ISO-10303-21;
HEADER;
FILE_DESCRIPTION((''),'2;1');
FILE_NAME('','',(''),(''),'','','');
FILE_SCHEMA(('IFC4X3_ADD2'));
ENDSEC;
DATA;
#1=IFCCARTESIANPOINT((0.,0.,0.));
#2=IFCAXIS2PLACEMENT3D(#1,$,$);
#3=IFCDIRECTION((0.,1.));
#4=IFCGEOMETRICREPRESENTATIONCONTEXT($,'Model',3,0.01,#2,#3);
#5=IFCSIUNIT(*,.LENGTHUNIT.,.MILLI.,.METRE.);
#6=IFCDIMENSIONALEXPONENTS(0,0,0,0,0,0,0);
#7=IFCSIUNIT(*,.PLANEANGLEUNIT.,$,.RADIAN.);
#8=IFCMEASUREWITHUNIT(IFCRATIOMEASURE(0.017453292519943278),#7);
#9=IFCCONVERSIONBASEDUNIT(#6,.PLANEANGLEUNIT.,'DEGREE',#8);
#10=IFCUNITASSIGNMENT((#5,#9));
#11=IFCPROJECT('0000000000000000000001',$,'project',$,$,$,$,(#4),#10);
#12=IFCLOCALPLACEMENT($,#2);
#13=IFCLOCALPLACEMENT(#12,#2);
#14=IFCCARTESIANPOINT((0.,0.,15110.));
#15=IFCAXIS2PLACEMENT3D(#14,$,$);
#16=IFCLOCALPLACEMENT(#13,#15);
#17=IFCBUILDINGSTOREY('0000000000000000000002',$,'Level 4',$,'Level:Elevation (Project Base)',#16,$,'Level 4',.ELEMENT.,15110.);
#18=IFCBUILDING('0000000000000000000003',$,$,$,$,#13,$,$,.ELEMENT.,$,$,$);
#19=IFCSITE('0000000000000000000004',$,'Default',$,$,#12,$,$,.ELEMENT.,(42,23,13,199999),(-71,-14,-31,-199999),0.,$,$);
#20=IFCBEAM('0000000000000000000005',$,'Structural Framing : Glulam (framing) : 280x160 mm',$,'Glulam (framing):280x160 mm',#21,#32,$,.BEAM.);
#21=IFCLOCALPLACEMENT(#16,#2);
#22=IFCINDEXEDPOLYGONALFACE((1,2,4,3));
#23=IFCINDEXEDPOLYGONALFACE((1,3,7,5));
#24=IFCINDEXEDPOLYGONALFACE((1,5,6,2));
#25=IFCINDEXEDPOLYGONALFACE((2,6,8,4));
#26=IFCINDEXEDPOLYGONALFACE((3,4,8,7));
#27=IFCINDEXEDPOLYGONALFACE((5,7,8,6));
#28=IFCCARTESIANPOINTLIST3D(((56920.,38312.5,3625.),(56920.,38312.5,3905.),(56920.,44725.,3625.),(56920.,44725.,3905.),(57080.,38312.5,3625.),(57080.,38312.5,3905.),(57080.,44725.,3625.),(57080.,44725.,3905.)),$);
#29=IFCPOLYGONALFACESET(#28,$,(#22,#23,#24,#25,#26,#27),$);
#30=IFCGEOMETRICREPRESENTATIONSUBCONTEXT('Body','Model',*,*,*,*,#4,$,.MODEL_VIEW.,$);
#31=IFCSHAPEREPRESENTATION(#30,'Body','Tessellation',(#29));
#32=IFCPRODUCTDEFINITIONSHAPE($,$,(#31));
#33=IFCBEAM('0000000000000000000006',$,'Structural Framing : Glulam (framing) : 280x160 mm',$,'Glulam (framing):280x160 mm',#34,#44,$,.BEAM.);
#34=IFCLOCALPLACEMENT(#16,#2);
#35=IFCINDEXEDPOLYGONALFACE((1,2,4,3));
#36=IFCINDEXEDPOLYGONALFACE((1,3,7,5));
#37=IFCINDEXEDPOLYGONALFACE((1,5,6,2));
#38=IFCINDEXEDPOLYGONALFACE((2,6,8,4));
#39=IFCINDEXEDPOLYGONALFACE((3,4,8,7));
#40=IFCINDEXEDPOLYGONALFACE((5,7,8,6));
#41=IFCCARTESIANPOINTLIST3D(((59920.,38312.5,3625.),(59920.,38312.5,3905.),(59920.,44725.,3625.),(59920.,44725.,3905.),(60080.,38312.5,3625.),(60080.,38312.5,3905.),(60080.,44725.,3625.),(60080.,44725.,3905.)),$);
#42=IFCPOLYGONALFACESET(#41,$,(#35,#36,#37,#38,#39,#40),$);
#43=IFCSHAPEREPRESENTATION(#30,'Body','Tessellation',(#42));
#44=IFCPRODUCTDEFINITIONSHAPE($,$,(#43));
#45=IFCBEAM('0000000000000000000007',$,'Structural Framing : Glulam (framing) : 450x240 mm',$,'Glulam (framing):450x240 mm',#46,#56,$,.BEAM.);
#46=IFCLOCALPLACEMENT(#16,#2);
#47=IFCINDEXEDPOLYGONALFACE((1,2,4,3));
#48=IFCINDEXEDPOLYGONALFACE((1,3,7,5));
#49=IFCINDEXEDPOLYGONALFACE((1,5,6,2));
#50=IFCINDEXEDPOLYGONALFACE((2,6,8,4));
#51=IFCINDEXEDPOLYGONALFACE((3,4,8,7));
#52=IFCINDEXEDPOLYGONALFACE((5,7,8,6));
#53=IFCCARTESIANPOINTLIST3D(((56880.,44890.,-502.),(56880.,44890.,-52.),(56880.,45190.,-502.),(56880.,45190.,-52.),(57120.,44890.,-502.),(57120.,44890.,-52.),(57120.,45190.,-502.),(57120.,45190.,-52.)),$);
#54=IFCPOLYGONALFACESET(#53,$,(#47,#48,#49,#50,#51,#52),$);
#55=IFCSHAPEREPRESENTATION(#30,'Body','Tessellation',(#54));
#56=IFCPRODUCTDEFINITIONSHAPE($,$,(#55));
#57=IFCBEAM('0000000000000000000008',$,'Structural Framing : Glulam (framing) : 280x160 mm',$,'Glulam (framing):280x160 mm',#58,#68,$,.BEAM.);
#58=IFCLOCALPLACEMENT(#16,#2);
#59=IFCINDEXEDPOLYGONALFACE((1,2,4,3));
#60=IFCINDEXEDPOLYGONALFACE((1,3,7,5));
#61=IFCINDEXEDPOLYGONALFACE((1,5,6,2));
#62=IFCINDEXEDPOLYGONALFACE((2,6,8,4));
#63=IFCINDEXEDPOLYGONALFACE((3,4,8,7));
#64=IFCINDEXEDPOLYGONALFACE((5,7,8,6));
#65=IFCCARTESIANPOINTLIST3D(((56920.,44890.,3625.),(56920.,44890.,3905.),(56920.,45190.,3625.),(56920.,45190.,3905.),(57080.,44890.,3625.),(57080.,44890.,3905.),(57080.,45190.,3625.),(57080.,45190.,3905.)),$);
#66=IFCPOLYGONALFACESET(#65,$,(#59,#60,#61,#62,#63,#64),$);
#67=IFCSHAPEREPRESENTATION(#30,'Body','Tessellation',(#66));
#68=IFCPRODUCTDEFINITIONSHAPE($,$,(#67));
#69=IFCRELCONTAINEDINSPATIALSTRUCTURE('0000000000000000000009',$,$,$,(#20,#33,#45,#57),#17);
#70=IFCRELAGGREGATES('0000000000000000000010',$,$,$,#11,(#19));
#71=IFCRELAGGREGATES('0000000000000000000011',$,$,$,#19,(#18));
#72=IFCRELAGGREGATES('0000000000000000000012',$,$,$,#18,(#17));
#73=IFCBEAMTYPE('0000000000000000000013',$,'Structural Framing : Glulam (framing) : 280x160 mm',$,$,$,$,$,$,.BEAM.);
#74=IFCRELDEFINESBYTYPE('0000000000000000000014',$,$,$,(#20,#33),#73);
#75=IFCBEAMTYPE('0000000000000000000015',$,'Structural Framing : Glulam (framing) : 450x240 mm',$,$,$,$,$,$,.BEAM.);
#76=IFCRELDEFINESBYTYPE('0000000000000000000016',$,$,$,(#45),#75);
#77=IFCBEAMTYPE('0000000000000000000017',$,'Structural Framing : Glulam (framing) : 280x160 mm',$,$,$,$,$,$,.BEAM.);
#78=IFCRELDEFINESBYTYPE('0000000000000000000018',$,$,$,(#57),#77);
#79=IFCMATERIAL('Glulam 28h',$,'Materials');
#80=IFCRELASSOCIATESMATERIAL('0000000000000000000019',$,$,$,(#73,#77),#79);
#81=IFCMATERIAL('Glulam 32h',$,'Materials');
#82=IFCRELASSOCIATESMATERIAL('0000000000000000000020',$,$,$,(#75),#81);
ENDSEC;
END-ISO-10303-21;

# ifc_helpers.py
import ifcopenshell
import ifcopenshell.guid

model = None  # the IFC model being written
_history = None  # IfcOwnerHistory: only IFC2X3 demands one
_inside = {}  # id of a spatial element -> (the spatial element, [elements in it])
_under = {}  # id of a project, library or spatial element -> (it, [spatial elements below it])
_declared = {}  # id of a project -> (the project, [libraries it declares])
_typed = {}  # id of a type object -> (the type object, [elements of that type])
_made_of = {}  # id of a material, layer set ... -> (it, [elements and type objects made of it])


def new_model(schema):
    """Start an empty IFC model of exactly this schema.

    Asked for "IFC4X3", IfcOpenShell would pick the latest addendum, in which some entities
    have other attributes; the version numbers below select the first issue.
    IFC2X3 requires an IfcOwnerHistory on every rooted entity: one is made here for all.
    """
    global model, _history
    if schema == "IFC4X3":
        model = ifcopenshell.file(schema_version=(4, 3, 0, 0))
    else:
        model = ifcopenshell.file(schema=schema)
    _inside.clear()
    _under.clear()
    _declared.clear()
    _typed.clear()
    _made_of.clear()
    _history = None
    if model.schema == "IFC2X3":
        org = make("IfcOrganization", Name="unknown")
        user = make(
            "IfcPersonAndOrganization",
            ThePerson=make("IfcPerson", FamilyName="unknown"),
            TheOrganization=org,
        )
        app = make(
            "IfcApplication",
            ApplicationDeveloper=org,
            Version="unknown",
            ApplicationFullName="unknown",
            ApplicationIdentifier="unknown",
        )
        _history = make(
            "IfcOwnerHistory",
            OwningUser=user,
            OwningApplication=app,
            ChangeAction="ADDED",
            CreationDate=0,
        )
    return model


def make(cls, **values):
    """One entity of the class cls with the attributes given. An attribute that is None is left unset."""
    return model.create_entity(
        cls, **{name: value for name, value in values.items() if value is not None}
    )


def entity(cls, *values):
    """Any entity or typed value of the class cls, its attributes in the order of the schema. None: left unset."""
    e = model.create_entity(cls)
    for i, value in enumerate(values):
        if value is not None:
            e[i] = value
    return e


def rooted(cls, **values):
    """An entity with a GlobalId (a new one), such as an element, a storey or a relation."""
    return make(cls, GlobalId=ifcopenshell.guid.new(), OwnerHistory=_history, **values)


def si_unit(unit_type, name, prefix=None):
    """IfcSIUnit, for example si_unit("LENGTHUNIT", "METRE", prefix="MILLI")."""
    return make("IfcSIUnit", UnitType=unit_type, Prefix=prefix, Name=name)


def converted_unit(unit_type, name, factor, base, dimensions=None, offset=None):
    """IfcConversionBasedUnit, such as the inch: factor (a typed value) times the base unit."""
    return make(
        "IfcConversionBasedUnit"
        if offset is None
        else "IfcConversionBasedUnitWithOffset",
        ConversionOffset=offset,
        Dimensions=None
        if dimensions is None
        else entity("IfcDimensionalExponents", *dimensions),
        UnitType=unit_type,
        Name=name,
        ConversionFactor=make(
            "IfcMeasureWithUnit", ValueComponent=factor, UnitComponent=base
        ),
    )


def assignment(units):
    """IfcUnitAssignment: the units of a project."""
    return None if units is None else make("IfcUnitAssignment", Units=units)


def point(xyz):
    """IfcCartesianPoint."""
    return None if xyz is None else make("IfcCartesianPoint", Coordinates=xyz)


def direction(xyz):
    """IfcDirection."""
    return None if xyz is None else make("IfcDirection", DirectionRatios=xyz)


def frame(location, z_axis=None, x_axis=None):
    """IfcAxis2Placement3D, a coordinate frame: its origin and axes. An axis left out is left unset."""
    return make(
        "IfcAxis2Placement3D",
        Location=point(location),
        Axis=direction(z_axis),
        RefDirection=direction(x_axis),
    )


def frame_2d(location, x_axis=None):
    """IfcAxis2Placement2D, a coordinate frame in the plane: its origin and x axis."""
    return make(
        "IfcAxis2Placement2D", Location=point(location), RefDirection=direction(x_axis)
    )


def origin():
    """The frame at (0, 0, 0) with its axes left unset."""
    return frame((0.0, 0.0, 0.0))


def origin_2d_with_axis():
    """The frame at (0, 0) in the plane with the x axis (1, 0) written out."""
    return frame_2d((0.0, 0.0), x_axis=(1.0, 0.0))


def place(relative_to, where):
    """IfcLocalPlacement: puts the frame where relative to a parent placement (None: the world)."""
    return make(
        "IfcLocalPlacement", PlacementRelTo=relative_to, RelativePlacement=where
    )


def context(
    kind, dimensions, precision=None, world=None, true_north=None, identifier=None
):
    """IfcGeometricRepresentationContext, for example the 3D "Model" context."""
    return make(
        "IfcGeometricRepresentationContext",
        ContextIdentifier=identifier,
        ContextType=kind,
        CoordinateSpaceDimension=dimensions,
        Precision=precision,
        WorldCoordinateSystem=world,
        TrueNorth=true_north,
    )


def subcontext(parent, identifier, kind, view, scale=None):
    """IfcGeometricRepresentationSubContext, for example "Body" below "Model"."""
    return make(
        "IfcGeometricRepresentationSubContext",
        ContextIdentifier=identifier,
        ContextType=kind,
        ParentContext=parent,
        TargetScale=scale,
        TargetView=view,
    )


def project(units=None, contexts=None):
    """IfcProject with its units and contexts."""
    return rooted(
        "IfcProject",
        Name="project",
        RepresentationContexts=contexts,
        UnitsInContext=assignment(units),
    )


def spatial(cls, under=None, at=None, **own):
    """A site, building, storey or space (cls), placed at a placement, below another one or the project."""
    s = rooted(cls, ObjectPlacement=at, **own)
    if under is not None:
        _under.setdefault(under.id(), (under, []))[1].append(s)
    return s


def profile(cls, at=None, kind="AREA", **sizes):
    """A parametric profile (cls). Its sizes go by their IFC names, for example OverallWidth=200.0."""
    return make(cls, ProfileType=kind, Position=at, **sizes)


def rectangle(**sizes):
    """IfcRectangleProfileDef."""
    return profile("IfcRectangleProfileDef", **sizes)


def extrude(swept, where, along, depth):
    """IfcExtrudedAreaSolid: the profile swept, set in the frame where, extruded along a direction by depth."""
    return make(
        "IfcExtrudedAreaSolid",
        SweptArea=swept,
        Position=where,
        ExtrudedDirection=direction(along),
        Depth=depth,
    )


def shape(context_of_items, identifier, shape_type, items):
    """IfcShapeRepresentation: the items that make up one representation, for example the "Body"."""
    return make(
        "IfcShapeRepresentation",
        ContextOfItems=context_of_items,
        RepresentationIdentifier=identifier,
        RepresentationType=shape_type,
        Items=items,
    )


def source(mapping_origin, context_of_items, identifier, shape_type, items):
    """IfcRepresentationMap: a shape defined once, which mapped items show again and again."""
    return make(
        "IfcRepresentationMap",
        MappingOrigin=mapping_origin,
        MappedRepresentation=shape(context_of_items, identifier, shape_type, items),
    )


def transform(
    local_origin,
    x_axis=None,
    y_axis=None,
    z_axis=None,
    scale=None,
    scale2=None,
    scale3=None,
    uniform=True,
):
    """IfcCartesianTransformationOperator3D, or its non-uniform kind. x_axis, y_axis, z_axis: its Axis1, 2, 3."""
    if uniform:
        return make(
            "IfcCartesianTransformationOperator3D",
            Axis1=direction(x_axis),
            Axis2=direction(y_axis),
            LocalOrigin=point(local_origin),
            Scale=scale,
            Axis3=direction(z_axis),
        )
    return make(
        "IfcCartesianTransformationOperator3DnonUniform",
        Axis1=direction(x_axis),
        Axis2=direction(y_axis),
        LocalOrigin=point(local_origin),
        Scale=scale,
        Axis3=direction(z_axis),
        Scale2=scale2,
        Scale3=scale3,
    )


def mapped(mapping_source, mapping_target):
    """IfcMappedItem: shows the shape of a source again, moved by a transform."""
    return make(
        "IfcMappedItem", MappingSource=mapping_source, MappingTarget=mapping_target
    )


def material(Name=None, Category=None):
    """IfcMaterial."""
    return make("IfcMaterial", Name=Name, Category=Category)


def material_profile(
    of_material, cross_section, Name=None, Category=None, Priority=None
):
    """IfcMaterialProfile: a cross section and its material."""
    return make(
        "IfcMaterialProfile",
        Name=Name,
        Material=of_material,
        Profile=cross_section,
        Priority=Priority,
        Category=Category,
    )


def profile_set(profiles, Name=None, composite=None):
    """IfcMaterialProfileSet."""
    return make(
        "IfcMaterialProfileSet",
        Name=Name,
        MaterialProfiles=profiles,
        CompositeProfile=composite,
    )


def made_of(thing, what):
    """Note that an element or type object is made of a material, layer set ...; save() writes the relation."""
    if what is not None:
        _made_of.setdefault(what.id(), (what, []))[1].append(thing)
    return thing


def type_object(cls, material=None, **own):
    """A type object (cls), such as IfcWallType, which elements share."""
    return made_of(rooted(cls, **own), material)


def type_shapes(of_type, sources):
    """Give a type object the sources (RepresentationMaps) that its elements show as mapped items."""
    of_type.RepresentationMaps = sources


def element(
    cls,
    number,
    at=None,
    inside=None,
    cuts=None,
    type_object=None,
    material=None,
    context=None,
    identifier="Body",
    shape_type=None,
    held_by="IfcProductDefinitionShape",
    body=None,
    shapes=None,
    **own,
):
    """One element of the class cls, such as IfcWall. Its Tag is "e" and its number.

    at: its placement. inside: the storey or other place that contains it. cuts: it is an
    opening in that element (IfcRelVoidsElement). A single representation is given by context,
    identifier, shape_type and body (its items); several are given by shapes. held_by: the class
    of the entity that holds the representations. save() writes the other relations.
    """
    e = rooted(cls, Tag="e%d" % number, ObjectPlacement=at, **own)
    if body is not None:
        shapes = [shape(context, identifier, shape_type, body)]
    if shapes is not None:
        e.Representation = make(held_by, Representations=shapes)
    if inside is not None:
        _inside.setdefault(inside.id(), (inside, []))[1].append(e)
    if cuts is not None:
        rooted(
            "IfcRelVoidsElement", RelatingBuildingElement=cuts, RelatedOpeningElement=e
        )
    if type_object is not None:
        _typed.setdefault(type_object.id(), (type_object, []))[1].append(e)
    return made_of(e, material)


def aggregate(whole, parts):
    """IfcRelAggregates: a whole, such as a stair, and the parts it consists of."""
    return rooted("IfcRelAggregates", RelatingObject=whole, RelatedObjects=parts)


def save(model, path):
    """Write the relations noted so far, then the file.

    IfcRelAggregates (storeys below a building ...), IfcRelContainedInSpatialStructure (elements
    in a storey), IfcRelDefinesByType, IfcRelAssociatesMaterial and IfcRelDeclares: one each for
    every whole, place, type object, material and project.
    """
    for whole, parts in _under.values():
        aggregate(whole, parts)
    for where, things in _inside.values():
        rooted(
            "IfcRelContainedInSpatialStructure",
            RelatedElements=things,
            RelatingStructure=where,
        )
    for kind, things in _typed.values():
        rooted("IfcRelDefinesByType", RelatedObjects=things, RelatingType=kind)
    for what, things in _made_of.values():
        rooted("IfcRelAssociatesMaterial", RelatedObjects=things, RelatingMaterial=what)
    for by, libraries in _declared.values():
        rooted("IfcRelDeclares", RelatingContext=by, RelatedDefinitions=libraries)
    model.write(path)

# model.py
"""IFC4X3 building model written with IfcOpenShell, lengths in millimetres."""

from ifc_helpers import new_model, entity, si_unit, converted_unit, direction, frame, origin, origin_2d_with_axis, place, context, subcontext, project, spatial, rectangle, extrude, source, transform, mapped, material, material_profile, profile_set, type_object, type_shapes, element, save


model = new_model("IFC4X3")

# Units and contexts
model_context = context("Model", 3, precision=0.01, world=origin(), true_north=direction((0.0, 1.0)))
body_context = subcontext(model_context, "Body", "Model", "MODEL_VIEW")
ifc_project = project(units=[si_unit("LENGTHUNIT", "METRE", prefix="MILLI"), converted_unit("PLANEANGLEUNIT", "DEGREE", entity("IfcRatioMeasure", 0.017453292519943278), si_unit("PLANEANGLEUNIT", "RADIAN"), dimensions=[0, 0, 0, 0, 0, 0, 0])], contexts=[model_context])

# Site, building, storey
site_placement = place(None, origin())
site = spatial("IfcSite", under=ifc_project, at=site_placement, Name="Default", CompositionType="ELEMENT", RefLatitude=(42, 23, 13, 199999), RefLongitude=(-71, -14, -31, -199999), RefElevation=0.0)
building_placement = place(site_placement, origin())
building = spatial("IfcBuilding", under=site, at=building_placement, CompositionType="ELEMENT")
storey_placement = place(building_placement, frame((0.0, 0.0, 15110.0)))
storey = spatial("IfcBuildingStorey", under=building, at=storey_placement, Name="Level 4", ObjectType="Level:Elevation (Project Base)", LongName="Level 4", CompositionType="ELEMENT", Elevation=15110.0)

# Beams
ifc_material_1 = material(Name="Glulam 28h", Category="Materials")
ifc_material_profile_1 = material_profile(ifc_material_1, rectangle(XDim=280.0, YDim=160.0, at=origin_2d_with_axis()), Name="280x160 mm")
ifc_profile_set_1 = profile_set([ifc_material_profile_1], Name="280x160 mm")
beam_type_1 = type_object("IfcBeamType", Name="Structural Framing : Glulam (framing) : 280x160 mm", PredefinedType="BEAM", material=ifc_profile_set_1)
shared_shape_1 = source(origin(), body_context, "Body", "SweptSolid", [
    extrude(rectangle(XDim=280.0, YDim=160.0, at=origin_2d_with_axis()), frame((-2932.5, 0.0, 0.0), z_axis=(1.0, 0.0, 0.0), x_axis=(0.0, 0.0, -1.0)), (0.0, 0.0, 1.0), 6412.5),
])
type_shapes(beam_type_1, [shared_shape_1])
for number, where, z_axis, x_axis, name in (
    (1, (57000.0, 41792.5, 3765.0), (0.0, 0.0, 1.0), (0.0, -1.0, 0.0), "Structural Framing : Glulam (framing) : 280x160 mm"),
    (2, (60000.0, 41792.5, 3765.0), (0.0, 0.0, 1.0), (0.0, -1.0, 0.0), "Structural Framing : Glulam (framing) : 280x160 mm"),
):
    element("IfcBeam", number, at=place(storey_placement, frame(where, z_axis=z_axis, x_axis=x_axis)), inside=storey, type_object=beam_type_1, Name=name, ObjectType="Glulam (framing):280x160 mm", PredefinedType="BEAM", context=body_context, shape_type="MappedRepresentation", body=[
        mapped(shared_shape_1, transform((0.0, 0.0, 0.0), scale=1.0)),
    ])
ifc_material_2 = material(Name="Glulam 32h", Category="Materials")
ifc_material_profile_2 = material_profile(ifc_material_2, rectangle(XDim=450.0, YDim=240.0, at=origin_2d_with_axis()), Name="450x240 mm")
ifc_profile_set_2 = profile_set([ifc_material_profile_2], Name="450x240 mm")
beam_type_2 = type_object("IfcBeamType", Name="Structural Framing : Glulam (framing) : 450x240 mm", PredefinedType="BEAM", material=ifc_profile_set_2)
shared_shape_2 = source(origin(), body_context, "Body", "SweptSolid", [
    extrude(rectangle(XDim=450.0, YDim=240.0, at=origin_2d_with_axis()), frame((-1110.0, 0.0, 0.0), z_axis=(1.0, 0.0, 0.0), x_axis=(0.0, 0.0, -1.0)), (0.0, 0.0, 1.0), 300.0),
])
type_shapes(beam_type_2, [shared_shape_2])
beam_1_placement = place(storey_placement, frame((57000.0, 44080.0, -277.0), z_axis=(0.0, 0.0, 1.0), x_axis=(0.0, -1.0, 0.0)))
element("IfcBeam", 3, at=beam_1_placement, inside=storey, type_object=beam_type_2, Name="Structural Framing : Glulam (framing) : 450x240 mm", ObjectType="Glulam (framing):450x240 mm", PredefinedType="BEAM", context=body_context, shape_type="MappedRepresentation", body=[
    mapped(shared_shape_2, transform((0.0, 0.0, 0.0), scale=1.0)),
])
beam_type_3 = type_object("IfcBeamType", Name="Structural Framing : Glulam (framing) : 280x160 mm", PredefinedType="BEAM", material=ifc_profile_set_1)
shared_shape_3 = source(origin(), body_context, "Body", "SweptSolid", [
    extrude(rectangle(XDim=280.0, YDim=160.0, at=origin_2d_with_axis()), frame((5322.5, 0.0, 0.0), z_axis=(1.0, 0.0, 0.0), x_axis=(0.0, 0.0, -1.0)), (0.0, 0.0, 1.0), 300.0),
])
type_shapes(beam_type_3, [shared_shape_3])
beam_2_placement = place(storey_placement, frame((57000.0, 50512.5, 3765.0), z_axis=(0.0, 0.0, 1.0), x_axis=(0.0, -1.0, 0.0)))
element("IfcBeam", 4, at=beam_2_placement, inside=storey, type_object=beam_type_3, Name="Structural Framing : Glulam (framing) : 280x160 mm", ObjectType="Glulam (framing):280x160 mm", PredefinedType="BEAM", context=body_context, shape_type="MappedRepresentation", body=[
    mapped(shared_shape_3, transform((0.0, 0.0, 0.0), scale=1.0)),
])

save(model, "model.ifc")
